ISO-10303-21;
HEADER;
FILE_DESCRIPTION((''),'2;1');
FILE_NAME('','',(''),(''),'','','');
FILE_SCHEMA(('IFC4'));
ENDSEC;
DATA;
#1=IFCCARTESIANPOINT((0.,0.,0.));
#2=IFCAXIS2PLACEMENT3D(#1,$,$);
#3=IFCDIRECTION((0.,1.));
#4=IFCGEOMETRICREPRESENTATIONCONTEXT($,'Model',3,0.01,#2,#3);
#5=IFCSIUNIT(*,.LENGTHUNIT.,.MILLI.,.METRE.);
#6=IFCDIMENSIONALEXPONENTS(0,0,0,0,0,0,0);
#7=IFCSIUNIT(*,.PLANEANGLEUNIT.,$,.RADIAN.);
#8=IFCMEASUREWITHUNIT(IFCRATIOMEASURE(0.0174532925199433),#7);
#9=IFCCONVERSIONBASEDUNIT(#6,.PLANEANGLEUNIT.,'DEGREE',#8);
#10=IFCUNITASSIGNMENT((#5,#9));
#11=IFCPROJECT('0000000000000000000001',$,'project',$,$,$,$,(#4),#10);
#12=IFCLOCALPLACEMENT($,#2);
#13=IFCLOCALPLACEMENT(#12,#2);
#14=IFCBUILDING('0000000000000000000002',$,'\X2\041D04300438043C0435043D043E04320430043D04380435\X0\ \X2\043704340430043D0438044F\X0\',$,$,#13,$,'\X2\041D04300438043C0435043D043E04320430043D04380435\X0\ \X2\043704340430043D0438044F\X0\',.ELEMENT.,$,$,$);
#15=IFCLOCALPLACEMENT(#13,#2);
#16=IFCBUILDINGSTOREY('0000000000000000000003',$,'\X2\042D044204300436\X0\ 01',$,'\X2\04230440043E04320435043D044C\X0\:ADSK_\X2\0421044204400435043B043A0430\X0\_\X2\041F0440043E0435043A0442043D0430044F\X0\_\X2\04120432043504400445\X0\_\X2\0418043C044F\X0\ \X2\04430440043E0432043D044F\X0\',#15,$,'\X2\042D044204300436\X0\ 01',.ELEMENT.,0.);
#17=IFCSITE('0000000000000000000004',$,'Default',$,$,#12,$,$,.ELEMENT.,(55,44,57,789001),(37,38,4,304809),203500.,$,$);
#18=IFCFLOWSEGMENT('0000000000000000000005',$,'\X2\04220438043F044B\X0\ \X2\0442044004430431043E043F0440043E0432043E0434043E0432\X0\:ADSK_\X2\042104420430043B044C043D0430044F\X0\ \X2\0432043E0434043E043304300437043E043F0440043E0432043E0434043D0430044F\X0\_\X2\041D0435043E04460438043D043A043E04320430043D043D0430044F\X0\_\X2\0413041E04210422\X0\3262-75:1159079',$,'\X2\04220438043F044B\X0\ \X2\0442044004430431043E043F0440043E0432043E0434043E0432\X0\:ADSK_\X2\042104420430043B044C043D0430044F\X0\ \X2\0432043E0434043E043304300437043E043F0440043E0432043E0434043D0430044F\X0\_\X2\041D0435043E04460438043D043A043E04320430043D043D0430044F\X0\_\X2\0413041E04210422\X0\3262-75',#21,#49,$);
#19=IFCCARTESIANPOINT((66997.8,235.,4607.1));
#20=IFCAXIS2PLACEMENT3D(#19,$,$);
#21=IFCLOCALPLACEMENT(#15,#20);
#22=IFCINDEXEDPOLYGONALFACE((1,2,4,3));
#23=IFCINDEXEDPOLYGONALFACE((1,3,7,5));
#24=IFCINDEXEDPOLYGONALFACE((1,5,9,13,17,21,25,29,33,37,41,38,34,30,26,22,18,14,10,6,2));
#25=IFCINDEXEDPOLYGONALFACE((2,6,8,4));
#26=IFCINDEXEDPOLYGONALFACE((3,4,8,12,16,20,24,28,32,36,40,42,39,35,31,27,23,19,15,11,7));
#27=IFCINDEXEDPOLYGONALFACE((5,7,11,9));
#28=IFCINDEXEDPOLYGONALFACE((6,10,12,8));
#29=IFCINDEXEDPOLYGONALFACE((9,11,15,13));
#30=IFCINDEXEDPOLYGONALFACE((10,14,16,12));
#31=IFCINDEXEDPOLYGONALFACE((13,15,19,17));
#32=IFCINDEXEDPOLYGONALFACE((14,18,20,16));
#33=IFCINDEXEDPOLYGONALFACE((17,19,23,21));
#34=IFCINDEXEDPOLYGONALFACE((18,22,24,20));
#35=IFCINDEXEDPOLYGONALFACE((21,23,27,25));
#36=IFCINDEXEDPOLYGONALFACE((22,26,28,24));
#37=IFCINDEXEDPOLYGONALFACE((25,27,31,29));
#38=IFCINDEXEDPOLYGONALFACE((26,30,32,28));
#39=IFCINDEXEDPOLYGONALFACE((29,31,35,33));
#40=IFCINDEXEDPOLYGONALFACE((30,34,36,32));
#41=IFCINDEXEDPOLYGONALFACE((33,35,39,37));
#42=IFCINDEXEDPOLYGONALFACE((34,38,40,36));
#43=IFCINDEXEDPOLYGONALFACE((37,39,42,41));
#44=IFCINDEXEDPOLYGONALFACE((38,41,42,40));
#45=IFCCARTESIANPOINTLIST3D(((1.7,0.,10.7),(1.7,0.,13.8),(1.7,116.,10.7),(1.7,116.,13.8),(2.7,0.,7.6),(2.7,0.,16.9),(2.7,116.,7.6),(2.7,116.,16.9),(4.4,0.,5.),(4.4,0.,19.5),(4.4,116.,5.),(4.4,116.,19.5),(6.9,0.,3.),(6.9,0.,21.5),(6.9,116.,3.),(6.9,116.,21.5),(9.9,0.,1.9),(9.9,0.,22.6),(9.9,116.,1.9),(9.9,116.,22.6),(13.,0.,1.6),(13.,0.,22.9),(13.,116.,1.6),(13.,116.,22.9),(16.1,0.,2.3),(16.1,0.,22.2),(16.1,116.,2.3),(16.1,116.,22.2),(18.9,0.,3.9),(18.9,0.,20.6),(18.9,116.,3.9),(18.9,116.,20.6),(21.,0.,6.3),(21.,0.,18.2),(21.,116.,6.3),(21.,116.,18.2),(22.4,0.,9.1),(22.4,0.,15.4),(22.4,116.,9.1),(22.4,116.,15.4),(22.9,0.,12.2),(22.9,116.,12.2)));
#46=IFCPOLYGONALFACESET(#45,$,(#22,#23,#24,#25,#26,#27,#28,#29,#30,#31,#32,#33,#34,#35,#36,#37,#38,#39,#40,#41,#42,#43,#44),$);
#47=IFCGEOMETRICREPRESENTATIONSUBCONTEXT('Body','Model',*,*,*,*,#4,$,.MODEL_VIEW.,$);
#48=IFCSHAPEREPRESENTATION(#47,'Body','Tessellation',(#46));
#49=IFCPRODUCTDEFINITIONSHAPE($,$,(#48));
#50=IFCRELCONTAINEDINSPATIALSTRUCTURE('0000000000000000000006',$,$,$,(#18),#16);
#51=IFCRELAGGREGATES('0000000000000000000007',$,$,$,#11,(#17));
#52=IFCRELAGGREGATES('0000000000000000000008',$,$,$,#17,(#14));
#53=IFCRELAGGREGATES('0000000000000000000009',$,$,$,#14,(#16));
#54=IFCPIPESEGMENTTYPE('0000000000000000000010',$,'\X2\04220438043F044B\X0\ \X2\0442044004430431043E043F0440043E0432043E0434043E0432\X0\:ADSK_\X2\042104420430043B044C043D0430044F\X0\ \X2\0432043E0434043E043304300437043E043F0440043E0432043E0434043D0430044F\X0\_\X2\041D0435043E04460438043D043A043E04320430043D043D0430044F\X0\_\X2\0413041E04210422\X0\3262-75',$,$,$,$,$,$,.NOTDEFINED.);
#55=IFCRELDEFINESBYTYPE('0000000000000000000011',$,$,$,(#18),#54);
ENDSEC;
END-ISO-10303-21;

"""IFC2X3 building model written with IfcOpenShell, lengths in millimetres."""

from ifc_helpers import new_model, entity, si_unit, converted_unit, direction, frame, origin, origin_2d_with_axis, place, context, subcontext, project, spatial, circle, extrude, type_object, element, save


model = new_model("IFC2X3")

# Units and contexts
model_context = context("Model", 3, precision=0.01, world=origin(), true_north=direction((0.0, 1.0)))
body_context = subcontext(model_context, "Body", "Model", "MODEL_VIEW")
ifc_project = project(units=[si_unit("LENGTHUNIT", "METRE", prefix="MILLI"), converted_unit("PLANEANGLEUNIT", "DEGREE", entity("IfcRatioMeasure", 0.0174532925199433), si_unit("PLANEANGLEUNIT", "RADIAN"), dimensions=[0, 0, 0, 0, 0, 0, 0])], contexts=[model_context])

# Site, building, storey
site_placement = place(None, origin())
site = spatial("IfcSite", under=ifc_project, at=site_placement, Name="Default", CompositionType="ELEMENT", RefLatitude=(55, 44, 57, 789001), RefLongitude=(37, 38, 4, 304809), RefElevation=203500.0)
building_placement = place(site_placement, origin())
building = spatial("IfcBuilding", under=site, at=building_placement, Name="Наименование здания", LongName="Наименование здания", CompositionType="ELEMENT")
storey_placement = place(building_placement, origin())
storey = spatial("IfcBuildingStorey", under=building, at=storey_placement, Name="Этаж 01", ObjectType="Уровень:ADSK_Стрелка_Проектная_Вверх_Имя уровня", LongName="Этаж 01", CompositionType="ELEMENT", Elevation=0.0)

# Flow segment
pipe_segment_type = type_object("IfcPipeSegmentType", Name="Типы трубопроводов:ADSK_Стальная водогазопроводная_Неоцинкованная_ГОСТ3262-75", PredefinedType="NOTDEFINED")
flow_segment_1_placement = place(storey_placement, frame((66997.8, 235.0, 4607.1)))
element("IfcFlowSegment", 1, at=flow_segment_1_placement, inside=storey, type_object=pipe_segment_type, Name="Типы трубопроводов:ADSK_Стальная водогазопроводная_Неоцинкованная_ГОСТ3262-75:1159079", ObjectType="Типы трубопроводов:ADSK_Стальная водогазопроводная_Неоцинкованная_ГОСТ3262-75", context=body_context, shape_type="SweptSolid", body=[
    extrude(circle(Radius=10.7, at=origin_2d_with_axis()), frame((12.2, 0.0, 12.2), z_axis=(0.0, 1.0, 0.0), x_axis=(1.0, 0.0, 0.0)), (0.0, 0.0, 1.0), 116.0),
])

save(model, "model.ifc")
